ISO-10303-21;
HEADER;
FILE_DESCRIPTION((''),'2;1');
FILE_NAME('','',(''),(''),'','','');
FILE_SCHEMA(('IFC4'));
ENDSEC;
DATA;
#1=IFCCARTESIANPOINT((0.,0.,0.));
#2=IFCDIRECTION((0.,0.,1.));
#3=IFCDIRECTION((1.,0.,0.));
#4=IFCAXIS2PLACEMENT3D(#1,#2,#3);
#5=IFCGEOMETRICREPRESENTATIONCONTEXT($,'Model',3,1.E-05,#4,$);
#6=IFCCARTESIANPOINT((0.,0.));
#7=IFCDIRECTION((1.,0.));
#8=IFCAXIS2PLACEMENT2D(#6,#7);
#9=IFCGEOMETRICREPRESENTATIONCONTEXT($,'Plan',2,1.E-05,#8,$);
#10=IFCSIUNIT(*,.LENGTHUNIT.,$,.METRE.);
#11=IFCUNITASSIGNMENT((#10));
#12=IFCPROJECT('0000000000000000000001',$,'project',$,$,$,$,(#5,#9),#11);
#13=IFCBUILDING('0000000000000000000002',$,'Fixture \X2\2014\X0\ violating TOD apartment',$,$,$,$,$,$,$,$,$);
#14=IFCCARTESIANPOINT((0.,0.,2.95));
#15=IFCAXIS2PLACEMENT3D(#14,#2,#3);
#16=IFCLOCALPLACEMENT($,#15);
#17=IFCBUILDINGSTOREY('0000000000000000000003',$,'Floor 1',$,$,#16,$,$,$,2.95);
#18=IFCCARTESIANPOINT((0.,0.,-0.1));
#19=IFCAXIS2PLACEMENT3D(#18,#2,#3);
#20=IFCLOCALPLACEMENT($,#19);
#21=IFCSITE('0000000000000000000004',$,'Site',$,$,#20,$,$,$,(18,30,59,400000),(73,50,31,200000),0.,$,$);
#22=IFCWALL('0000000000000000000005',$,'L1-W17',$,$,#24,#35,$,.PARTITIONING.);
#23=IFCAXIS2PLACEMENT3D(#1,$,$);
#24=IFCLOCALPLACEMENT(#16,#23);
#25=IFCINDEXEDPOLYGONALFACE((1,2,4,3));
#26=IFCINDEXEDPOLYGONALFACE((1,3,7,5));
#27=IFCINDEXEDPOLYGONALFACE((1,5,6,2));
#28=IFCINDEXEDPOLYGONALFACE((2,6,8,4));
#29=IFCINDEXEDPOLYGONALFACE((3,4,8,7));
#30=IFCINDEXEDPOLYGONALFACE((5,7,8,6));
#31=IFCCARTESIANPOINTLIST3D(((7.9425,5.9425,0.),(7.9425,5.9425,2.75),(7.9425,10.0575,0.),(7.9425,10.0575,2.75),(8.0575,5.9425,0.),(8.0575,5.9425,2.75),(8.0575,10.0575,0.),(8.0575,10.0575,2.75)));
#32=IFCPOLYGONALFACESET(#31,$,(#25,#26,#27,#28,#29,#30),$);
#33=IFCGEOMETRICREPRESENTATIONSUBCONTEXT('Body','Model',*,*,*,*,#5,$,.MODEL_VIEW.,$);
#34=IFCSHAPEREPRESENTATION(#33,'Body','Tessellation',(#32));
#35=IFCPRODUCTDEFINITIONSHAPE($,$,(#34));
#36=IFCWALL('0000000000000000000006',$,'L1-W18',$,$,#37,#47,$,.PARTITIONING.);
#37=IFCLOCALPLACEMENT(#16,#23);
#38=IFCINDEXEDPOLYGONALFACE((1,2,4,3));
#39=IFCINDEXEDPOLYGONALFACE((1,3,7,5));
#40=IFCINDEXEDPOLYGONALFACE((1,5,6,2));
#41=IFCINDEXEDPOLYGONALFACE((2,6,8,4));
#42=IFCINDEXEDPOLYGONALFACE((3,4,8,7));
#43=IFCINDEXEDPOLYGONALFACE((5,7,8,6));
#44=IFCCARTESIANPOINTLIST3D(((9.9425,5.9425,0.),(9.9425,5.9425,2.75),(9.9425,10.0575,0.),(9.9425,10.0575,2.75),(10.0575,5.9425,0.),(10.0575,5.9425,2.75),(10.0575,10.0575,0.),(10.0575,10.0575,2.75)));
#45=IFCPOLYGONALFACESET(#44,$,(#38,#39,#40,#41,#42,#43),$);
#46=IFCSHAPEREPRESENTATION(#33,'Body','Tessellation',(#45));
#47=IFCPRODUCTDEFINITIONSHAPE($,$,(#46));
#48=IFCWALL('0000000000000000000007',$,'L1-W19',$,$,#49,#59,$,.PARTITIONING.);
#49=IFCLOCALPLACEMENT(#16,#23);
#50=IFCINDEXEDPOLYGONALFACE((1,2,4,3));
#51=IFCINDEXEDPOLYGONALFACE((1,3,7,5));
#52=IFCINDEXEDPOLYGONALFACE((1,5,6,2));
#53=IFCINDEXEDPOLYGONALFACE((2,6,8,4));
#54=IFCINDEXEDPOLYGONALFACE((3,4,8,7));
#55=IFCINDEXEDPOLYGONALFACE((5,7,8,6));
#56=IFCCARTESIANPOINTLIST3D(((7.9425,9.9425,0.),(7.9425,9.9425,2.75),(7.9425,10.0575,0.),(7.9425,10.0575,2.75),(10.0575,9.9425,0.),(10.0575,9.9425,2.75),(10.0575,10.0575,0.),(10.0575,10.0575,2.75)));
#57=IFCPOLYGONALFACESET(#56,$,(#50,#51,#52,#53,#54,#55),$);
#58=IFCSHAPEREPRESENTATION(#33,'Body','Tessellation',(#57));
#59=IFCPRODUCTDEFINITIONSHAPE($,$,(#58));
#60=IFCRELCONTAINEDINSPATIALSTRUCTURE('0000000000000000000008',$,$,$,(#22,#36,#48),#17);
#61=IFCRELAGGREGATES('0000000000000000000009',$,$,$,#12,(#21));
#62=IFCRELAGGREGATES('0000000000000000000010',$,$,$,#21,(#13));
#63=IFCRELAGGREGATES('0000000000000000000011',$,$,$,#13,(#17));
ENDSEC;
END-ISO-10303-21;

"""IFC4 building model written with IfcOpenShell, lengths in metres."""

from ifc_helpers import new_model, si_unit, frame, origin_with_axes, origin_2d_with_axis, place, context, subcontext, project, spatial, line, indexed_curve, outline, extrude, element, save


model = new_model("IFC4")

# Units and contexts
model_context = context("Model", 3, precision=1e-05, world=origin_with_axes())
plan_context = context("Plan", 2, precision=1e-05, world=origin_2d_with_axis())
body_context = subcontext(model_context, "Body", "Model", "MODEL_VIEW")
ifc_project = project(units=[si_unit("LENGTHUNIT", "METRE")], contexts=[model_context, plan_context])

# Site, building, storey
site_placement = place(None, frame((0.0, 0.0, -0.1), z_axis=(0.0, 0.0, 1.0), x_axis=(1.0, 0.0, 0.0)))
site = spatial("IfcSite", under=ifc_project, at=site_placement, Name="Site", RefLatitude=(18, 30, 59, 400000), RefLongitude=(73, 50, 31, 200000), RefElevation=0.0)
building = spatial("IfcBuilding", under=site, Name="Fixture — violating TOD apartment")
storey_placement = place(None, frame((0.0, 0.0, 2.95), z_axis=(0.0, 0.0, 1.0), x_axis=(1.0, 0.0, 0.0)))
storey = spatial("IfcBuildingStorey", under=building, at=storey_placement, Name="Floor 1", Elevation=2.95)

# Walls
wall_1_placement = place(storey_placement, frame((0.0, 0.0, -2.95), z_axis=(0.0, 0.0, 1.0), x_axis=(1.0, 0.0, 0.0)))
element("IfcWall", 1, at=wall_1_placement, inside=storey, Name="L1-W17", PredefinedType="PARTITIONING", context=body_context, shape_type="SweptSolid", body=[
    extrude(outline(indexed_curve([(7.9425, 5.9425), (7.9425, 10.0575), (8.0575, 10.0575), (8.0575, 5.9425)], segments=[line(1, 2, 3, 4, 1)])), frame((0.0, 0.0, 2.95), z_axis=(0.0, 0.0, 1.0), x_axis=(1.0, 0.0, 0.0)), (0.0, 0.0, 1.0), 2.75),
])
wall_2_placement = place(storey_placement, frame((0.0, 0.0, -2.95), z_axis=(0.0, 0.0, 1.0), x_axis=(1.0, 0.0, 0.0)))
element("IfcWall", 2, at=wall_2_placement, inside=storey, Name="L1-W18", PredefinedType="PARTITIONING", context=body_context, shape_type="SweptSolid", body=[
    extrude(outline(indexed_curve([(9.9425, 5.9425), (9.9425, 10.0575), (10.0575, 10.0575), (10.0575, 5.9425)], segments=[line(1, 2, 3, 4, 1)])), frame((0.0, 0.0, 2.95), z_axis=(0.0, 0.0, 1.0), x_axis=(1.0, 0.0, 0.0)), (0.0, 0.0, 1.0), 2.75),
])
wall_3_placement = place(storey_placement, frame((0.0, 0.0, -2.95), z_axis=(0.0, 0.0, 1.0), x_axis=(1.0, 0.0, 0.0)))
element("IfcWall", 3, at=wall_3_placement, inside=storey, Name="L1-W19", PredefinedType="PARTITIONING", context=body_context, shape_type="SweptSolid", body=[
    extrude(outline(indexed_curve([(10.0575, 9.9425), (7.9425, 9.9425), (7.9425, 10.0575), (10.0575, 10.0575)], segments=[line(1, 2, 3, 4, 1)])), frame((0.0, 0.0, 2.95), z_axis=(0.0, 0.0, 1.0), x_axis=(1.0, 0.0, 0.0)), (0.0, 0.0, 1.0), 2.75),
])

save(model, "model.ifc")
